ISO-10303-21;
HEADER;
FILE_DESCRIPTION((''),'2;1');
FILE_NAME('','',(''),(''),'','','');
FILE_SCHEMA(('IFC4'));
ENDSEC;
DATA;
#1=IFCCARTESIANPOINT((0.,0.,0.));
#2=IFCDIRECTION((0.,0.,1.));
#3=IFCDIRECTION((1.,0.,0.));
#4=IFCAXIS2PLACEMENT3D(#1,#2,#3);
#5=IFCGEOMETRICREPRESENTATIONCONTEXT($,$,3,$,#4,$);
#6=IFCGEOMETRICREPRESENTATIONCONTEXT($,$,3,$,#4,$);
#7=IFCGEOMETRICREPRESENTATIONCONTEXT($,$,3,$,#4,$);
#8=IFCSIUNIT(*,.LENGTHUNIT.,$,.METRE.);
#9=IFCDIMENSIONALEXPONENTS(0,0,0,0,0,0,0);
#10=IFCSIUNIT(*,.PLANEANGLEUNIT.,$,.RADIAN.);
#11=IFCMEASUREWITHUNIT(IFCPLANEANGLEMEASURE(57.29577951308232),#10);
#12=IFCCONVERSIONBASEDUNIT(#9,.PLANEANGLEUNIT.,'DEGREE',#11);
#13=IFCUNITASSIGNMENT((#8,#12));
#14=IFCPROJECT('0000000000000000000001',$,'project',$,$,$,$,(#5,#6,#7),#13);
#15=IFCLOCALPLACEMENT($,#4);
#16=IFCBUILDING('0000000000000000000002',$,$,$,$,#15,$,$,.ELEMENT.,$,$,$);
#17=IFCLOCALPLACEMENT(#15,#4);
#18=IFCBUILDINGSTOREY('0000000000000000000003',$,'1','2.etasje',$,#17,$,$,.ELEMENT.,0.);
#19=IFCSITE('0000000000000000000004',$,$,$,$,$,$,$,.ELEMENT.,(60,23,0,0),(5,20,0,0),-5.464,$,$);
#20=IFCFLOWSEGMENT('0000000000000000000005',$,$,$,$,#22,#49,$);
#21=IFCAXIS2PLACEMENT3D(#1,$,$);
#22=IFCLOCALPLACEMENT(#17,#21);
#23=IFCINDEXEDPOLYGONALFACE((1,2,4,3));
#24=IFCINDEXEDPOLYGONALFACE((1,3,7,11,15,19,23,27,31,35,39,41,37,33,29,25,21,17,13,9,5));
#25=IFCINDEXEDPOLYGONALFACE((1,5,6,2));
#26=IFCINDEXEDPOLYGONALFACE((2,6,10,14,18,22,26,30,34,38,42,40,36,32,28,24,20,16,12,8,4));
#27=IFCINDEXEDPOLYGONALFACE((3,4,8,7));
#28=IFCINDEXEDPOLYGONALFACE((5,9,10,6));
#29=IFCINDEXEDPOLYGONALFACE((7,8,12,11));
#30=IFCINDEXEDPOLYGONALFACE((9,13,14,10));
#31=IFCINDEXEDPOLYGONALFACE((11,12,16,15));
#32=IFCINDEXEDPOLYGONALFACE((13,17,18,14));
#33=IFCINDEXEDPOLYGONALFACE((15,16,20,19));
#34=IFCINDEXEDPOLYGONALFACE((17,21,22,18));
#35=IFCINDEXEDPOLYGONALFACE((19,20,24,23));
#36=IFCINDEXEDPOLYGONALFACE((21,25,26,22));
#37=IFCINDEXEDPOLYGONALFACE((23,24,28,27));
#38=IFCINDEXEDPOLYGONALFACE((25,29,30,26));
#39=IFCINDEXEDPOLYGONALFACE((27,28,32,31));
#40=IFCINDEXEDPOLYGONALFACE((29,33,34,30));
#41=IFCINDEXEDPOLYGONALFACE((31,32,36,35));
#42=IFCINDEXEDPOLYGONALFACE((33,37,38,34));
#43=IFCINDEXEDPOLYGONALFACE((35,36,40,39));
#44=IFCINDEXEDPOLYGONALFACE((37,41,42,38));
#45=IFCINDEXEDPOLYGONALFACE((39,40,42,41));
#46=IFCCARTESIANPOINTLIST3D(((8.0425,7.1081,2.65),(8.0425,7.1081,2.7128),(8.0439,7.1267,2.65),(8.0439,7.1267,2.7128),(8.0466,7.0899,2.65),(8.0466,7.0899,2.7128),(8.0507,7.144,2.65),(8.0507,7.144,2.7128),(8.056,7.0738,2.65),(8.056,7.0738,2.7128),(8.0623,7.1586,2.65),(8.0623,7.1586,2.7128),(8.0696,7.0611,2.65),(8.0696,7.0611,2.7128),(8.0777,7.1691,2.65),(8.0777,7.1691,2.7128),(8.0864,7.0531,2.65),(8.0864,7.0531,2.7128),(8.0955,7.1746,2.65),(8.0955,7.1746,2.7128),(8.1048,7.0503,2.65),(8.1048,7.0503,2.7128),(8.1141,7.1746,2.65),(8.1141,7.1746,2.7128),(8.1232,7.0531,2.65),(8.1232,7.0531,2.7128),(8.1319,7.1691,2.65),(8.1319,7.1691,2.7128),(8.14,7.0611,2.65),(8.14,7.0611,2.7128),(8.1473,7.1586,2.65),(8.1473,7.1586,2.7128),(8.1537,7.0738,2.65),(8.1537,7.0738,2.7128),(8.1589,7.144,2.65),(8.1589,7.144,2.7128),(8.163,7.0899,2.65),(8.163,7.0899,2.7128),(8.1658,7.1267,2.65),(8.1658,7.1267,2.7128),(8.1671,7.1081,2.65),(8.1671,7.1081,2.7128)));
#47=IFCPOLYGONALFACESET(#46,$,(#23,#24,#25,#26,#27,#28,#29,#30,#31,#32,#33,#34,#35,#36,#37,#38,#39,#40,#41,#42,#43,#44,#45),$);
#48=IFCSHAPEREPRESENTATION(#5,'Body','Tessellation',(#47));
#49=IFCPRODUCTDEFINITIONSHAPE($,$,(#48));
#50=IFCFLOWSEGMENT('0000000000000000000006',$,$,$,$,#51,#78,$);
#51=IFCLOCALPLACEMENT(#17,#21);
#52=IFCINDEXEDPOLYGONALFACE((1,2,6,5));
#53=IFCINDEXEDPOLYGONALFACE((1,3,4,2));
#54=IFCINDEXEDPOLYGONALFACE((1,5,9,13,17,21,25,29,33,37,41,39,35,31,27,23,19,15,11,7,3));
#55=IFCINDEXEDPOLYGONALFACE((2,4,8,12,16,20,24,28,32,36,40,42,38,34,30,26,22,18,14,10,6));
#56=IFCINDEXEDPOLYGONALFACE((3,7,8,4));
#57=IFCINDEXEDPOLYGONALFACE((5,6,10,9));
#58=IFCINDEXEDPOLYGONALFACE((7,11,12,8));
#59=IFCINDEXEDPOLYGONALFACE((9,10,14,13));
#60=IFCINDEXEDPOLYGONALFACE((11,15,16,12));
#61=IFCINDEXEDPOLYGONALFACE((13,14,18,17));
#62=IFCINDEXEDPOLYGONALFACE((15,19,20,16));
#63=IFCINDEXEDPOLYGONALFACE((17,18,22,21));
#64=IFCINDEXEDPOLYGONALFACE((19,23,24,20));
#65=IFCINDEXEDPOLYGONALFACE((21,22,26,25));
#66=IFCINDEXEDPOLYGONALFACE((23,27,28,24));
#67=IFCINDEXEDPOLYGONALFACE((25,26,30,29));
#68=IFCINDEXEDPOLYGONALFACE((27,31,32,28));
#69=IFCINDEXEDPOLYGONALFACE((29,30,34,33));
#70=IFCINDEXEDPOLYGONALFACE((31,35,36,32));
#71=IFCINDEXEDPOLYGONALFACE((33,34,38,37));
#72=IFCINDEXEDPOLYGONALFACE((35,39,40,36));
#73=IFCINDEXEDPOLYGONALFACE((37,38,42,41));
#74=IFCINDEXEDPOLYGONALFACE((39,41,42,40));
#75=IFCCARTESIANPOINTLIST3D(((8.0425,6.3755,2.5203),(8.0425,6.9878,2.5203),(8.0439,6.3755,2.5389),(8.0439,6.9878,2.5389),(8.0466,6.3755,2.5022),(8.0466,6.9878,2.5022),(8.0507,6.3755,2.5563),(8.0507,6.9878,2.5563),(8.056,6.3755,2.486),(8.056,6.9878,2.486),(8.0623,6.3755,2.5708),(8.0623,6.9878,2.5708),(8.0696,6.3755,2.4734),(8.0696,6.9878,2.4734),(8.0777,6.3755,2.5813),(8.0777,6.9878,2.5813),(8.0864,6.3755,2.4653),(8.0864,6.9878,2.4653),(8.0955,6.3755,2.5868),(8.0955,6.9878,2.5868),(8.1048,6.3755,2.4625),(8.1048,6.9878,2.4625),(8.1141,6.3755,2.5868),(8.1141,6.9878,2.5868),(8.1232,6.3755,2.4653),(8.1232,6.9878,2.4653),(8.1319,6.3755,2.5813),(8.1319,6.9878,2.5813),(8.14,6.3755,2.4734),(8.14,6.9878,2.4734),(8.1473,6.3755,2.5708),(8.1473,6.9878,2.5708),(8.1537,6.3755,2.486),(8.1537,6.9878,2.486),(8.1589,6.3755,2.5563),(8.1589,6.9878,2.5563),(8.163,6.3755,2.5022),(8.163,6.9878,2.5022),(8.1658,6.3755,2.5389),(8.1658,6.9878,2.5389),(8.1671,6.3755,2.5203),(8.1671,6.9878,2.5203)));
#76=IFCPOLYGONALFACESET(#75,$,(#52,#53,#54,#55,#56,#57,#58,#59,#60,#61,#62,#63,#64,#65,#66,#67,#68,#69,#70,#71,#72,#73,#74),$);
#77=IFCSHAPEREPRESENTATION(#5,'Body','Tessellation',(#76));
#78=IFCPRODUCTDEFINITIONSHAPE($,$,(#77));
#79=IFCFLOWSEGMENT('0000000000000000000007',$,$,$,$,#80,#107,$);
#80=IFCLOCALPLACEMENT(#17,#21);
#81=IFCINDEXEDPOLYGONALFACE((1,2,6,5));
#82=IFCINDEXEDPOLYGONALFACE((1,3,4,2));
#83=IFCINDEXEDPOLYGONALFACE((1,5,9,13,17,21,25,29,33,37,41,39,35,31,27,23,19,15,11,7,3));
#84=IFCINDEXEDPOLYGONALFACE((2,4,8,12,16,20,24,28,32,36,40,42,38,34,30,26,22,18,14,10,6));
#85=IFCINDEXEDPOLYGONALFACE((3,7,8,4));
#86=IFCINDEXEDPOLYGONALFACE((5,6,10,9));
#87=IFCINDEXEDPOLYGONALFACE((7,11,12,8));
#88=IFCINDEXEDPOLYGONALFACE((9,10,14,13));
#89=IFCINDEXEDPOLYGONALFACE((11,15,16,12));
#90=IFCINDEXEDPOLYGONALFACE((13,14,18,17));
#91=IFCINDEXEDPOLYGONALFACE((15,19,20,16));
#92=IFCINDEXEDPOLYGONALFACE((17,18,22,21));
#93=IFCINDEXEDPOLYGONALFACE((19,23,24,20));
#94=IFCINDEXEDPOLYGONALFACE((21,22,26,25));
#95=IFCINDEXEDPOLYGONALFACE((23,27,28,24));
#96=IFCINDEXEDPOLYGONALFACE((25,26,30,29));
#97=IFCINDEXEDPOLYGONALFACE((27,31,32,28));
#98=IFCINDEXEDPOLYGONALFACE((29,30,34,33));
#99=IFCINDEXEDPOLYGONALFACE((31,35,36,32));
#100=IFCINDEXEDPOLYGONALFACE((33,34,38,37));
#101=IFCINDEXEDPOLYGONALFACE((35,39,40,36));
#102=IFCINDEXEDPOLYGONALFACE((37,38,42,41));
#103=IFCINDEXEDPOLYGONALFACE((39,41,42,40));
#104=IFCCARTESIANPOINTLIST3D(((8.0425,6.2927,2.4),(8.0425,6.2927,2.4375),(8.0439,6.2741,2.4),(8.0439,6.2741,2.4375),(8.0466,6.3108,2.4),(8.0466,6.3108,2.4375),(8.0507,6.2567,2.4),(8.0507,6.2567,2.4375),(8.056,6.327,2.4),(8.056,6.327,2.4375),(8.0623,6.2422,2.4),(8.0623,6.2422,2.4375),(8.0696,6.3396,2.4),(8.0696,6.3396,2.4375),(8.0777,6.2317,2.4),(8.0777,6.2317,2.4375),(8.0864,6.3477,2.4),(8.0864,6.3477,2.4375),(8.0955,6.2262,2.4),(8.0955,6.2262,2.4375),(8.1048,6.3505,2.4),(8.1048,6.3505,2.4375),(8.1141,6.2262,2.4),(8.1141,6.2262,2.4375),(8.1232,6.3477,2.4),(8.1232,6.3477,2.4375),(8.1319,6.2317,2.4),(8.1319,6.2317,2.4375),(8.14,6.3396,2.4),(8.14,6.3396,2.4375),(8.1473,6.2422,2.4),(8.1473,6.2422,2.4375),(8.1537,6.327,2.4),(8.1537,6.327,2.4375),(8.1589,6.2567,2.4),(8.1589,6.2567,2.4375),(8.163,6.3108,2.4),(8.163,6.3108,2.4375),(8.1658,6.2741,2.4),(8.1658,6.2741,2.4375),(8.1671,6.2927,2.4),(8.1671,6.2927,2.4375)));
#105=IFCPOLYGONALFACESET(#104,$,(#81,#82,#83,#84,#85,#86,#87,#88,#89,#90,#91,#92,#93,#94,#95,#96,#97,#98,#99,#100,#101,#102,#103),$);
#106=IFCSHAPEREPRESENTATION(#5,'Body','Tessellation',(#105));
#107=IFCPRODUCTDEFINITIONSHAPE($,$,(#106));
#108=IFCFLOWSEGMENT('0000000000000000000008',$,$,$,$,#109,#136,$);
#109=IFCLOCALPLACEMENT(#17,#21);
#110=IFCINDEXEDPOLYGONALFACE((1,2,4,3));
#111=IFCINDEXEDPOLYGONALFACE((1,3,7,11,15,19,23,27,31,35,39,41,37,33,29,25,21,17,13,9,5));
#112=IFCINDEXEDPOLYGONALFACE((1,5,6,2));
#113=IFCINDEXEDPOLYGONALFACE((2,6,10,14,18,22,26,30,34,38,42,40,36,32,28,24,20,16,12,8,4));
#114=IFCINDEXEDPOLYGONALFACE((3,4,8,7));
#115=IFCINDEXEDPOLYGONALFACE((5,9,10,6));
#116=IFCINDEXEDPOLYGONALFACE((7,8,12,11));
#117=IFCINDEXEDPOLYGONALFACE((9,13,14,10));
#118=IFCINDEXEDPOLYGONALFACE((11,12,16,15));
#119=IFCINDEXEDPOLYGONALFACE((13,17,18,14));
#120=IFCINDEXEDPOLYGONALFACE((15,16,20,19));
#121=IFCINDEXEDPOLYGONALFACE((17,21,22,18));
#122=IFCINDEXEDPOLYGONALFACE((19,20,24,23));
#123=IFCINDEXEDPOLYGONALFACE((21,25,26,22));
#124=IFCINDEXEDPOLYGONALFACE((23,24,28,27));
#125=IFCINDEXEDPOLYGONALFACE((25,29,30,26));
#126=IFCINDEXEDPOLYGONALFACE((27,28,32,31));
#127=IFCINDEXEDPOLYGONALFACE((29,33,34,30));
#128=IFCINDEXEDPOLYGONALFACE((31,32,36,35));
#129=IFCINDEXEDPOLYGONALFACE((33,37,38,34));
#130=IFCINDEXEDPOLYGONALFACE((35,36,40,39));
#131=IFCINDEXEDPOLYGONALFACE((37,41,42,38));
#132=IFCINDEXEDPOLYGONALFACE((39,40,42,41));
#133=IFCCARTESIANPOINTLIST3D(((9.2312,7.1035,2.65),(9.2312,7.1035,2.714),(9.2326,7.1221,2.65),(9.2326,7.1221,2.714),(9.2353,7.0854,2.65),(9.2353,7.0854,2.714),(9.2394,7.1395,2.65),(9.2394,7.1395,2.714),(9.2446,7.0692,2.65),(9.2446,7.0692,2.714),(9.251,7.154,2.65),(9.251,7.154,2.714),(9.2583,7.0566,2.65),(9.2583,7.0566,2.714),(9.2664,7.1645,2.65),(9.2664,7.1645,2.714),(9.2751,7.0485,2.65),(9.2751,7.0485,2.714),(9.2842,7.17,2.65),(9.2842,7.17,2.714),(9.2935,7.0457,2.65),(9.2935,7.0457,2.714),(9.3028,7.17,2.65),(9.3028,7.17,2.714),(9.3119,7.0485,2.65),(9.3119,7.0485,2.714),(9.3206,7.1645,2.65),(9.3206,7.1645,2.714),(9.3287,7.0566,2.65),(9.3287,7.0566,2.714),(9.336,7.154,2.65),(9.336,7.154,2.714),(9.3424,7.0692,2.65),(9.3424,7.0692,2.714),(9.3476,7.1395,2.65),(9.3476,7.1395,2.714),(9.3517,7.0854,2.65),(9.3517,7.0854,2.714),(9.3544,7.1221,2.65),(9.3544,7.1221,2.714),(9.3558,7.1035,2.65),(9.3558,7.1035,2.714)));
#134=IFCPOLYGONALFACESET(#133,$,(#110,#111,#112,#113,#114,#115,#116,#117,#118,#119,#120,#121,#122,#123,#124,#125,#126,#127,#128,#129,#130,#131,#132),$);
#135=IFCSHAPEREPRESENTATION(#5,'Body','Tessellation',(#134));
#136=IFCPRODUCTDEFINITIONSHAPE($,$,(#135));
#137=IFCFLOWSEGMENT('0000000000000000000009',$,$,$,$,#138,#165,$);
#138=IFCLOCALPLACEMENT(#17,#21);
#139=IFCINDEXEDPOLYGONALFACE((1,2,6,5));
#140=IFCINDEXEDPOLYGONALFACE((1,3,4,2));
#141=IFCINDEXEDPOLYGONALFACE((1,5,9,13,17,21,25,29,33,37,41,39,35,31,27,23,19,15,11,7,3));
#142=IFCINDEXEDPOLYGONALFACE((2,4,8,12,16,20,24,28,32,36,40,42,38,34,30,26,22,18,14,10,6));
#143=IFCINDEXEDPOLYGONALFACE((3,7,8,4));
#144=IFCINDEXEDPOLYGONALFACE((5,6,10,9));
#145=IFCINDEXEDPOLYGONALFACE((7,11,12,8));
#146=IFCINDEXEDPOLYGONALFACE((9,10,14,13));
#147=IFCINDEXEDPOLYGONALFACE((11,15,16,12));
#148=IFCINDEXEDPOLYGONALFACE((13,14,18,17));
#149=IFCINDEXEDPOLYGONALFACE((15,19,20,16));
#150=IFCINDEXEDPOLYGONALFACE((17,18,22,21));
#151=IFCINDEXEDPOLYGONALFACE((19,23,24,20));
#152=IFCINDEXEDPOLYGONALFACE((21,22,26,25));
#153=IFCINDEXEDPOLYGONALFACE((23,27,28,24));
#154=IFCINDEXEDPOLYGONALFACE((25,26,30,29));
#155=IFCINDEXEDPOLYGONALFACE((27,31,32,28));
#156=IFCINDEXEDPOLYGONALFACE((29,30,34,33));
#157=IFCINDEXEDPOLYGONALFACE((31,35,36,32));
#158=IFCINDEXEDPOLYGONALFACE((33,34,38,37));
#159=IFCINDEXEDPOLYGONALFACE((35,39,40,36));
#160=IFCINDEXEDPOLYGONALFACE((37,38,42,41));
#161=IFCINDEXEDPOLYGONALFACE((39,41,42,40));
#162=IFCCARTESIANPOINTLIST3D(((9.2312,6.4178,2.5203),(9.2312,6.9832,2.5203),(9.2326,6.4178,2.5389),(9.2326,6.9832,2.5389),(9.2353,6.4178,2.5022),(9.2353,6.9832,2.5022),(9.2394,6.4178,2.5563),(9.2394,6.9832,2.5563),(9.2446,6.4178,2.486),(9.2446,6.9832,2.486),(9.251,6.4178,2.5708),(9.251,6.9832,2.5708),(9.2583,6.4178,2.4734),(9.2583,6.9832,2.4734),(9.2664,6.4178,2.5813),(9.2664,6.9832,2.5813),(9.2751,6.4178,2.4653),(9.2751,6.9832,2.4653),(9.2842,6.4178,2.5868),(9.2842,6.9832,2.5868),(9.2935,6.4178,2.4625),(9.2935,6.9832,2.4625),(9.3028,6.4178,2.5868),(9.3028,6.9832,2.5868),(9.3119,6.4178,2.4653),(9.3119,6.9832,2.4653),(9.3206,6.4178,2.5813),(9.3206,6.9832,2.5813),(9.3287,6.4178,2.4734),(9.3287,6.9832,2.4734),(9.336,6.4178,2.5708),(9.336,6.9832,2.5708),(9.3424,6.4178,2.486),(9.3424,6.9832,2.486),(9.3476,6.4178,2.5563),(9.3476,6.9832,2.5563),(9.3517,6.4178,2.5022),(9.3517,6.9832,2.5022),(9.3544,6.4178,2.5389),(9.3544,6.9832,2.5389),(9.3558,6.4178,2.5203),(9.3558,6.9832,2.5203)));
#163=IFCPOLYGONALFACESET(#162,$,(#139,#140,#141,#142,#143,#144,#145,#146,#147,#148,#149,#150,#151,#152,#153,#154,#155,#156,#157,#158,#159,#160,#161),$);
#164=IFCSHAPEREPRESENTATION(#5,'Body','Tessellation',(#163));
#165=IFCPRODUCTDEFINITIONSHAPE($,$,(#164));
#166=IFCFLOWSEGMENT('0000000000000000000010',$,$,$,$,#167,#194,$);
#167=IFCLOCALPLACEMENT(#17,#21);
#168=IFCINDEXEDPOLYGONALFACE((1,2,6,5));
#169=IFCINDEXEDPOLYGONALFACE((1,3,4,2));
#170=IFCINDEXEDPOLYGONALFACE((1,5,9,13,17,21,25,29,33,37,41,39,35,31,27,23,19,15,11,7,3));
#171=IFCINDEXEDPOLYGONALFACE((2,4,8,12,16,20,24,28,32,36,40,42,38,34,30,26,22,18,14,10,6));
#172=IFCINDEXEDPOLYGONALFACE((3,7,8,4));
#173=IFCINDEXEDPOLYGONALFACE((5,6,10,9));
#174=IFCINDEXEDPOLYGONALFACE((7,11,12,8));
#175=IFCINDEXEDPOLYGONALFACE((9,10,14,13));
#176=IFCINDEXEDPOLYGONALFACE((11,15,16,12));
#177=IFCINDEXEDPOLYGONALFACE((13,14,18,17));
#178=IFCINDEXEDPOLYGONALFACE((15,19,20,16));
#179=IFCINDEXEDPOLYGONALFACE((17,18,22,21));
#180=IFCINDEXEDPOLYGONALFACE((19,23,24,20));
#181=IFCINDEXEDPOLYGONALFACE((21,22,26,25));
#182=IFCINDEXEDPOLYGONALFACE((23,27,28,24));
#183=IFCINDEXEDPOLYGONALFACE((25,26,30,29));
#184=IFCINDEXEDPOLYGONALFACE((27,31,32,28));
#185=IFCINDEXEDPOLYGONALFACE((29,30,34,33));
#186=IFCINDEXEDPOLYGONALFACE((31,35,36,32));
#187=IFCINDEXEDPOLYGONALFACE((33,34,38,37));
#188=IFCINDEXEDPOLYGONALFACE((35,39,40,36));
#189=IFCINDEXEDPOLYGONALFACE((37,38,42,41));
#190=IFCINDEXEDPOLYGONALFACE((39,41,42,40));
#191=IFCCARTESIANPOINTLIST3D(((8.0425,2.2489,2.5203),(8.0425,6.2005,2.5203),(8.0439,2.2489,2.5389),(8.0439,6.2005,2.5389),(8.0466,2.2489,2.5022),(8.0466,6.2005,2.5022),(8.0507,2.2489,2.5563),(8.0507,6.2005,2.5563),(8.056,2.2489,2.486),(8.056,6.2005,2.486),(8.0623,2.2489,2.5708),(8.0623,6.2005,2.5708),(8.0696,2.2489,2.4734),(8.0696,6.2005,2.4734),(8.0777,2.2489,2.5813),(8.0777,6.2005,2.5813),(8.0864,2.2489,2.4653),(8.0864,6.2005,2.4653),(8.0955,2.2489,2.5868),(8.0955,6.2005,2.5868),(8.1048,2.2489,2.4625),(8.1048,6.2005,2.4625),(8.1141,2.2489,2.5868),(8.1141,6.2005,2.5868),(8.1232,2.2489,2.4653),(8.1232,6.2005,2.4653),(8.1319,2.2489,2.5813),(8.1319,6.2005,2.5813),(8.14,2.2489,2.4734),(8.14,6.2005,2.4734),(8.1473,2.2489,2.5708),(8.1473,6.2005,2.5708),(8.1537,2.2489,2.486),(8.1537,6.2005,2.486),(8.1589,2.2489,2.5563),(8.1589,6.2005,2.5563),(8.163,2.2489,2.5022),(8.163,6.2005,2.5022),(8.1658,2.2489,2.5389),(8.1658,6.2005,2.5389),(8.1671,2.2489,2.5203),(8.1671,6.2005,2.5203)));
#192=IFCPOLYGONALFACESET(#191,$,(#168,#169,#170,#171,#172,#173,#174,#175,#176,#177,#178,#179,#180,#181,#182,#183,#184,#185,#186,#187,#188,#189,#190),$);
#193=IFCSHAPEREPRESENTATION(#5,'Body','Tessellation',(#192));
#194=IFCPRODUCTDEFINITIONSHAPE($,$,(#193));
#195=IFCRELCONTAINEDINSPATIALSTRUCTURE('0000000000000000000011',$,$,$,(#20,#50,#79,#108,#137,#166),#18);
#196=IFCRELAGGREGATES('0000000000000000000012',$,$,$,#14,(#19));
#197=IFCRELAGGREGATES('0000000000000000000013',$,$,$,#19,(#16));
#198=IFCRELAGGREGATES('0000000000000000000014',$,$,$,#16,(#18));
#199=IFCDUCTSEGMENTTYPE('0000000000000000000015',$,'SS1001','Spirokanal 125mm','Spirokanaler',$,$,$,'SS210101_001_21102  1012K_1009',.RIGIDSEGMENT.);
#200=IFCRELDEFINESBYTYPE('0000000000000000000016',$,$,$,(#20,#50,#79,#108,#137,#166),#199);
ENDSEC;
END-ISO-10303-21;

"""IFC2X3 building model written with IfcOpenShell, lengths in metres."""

from ifc_helpers import new_model, entity, si_unit, converted_unit, frame, origin_with_axes, origin_2d_with_axis, place, context, project, spatial, circle, extrude, type_object, element, save


model = new_model("IFC2X3")

# Units and contexts
context_of_model_1 = context(None, 3, world=origin_with_axes())
context_of_model_2 = context(None, 3, world=origin_with_axes())
context_of_model_3 = context(None, 3, world=origin_with_axes())
ifc_project = project(units=[si_unit("LENGTHUNIT", "METRE"), converted_unit("PLANEANGLEUNIT", "DEGREE", entity("IfcPlaneAngleMeasure", 57.29577951308232), si_unit("PLANEANGLEUNIT", "RADIAN"), dimensions=[0, 0, 0, 0, 0, 0, 0])], contexts=[context_of_model_1, context_of_model_2, context_of_model_3])

# Site, building, storey
site = spatial("IfcSite", under=ifc_project, CompositionType="ELEMENT", RefLatitude=(60, 23, 0, 0), RefLongitude=(5, 20, 0, 0), RefElevation=-5.464)
building_placement = place(None, origin_with_axes())
building = spatial("IfcBuilding", under=site, at=building_placement, CompositionType="ELEMENT")
storey_placement = place(building_placement, origin_with_axes())
storey = spatial("IfcBuildingStorey", under=building, at=storey_placement, Name="1", Description="2.etasje", CompositionType="ELEMENT", Elevation=0.0)

# Flow segments
duct_segment_type_1 = type_object("IfcDuctSegmentType", Name="SS1001", Description="Spirokanal 125mm", ApplicableOccurrence="Spirokanaler", ElementType="SS210101_001_21102  1012K_1009", PredefinedType="RIGIDSEGMENT")
flow_segment_1_placement = place(storey_placement, frame((8.1048, 7.1128, 2.7128), z_axis=(0.0, 0.0, -1.0), x_axis=(0.0, -1.0, 0.0)))
element("IfcFlowSegment", 1, at=flow_segment_1_placement, inside=storey, type_object=duct_segment_type_1, context=context_of_model_1, shape_type="SweptSolid", body=[
    extrude(circle(Radius=0.0625, at=origin_2d_with_axis()), origin_with_axes(), (0.0, 0.0, 1.0), 0.0628),
])
flow_segment_2_placement = place(storey_placement, frame((8.1048, 6.9878, 2.525), z_axis=(0.0, -1.0, 0.0), x_axis=(0.0, 0.0, -1.0)))
element("IfcFlowSegment", 2, at=flow_segment_2_placement, inside=storey, type_object=duct_segment_type_1, context=context_of_model_1, shape_type="SweptSolid", body=[
    extrude(circle(Radius=0.0625, at=origin_2d_with_axis()), origin_with_axes(), (0.0, 0.0, 1.0), 0.6123),
])
flow_segment_3_placement = place(storey_placement, frame((8.1048, 6.288, 2.4375), z_axis=(0.0, 0.0, -1.0), x_axis=(0.0, 1.0, 0.0)))
element("IfcFlowSegment", 3, at=flow_segment_3_placement, inside=storey, type_object=duct_segment_type_1, context=context_of_model_1, shape_type="SweptSolid", body=[
    extrude(circle(Radius=0.0625, at=origin_2d_with_axis()), origin_with_axes(), (0.0, 0.0, 1.0), 0.0375),
])
flow_segment_4_placement = place(storey_placement, frame((9.2935, 7.1082, 2.714), z_axis=(0.0, 0.0, -1.0), x_axis=(0.0, -1.0, 0.0)))
element("IfcFlowSegment", 4, at=flow_segment_4_placement, inside=storey, type_object=duct_segment_type_1, context=context_of_model_1, shape_type="SweptSolid", body=[
    extrude(circle(Radius=0.0625, at=origin_2d_with_axis()), origin_with_axes(), (0.0, 0.0, 1.0), 0.064),
])
flow_segment_5_placement = place(storey_placement, frame((9.2935, 6.9832, 2.525), z_axis=(0.0, -1.0, 0.0), x_axis=(0.0, 0.0, -1.0)))
element("IfcFlowSegment", 5, at=flow_segment_5_placement, inside=storey, type_object=duct_segment_type_1, context=context_of_model_1, shape_type="SweptSolid", body=[
    extrude(circle(Radius=0.0625, at=origin_2d_with_axis()), origin_with_axes(), (0.0, 0.0, 1.0), 0.5654),
])
flow_segment_6_placement = place(storey_placement, frame((8.1048, 6.2005, 2.525), z_axis=(0.0, -1.0, 0.0), x_axis=(0.0, 0.0, -1.0)))
element("IfcFlowSegment", 6, at=flow_segment_6_placement, inside=storey, type_object=duct_segment_type_1, context=context_of_model_1, shape_type="SweptSolid", body=[
    extrude(circle(Radius=0.0625, at=origin_2d_with_axis()), origin_with_axes(), (0.0, 0.0, 1.0), 3.9516),
])

save(model, "model.ifc")
